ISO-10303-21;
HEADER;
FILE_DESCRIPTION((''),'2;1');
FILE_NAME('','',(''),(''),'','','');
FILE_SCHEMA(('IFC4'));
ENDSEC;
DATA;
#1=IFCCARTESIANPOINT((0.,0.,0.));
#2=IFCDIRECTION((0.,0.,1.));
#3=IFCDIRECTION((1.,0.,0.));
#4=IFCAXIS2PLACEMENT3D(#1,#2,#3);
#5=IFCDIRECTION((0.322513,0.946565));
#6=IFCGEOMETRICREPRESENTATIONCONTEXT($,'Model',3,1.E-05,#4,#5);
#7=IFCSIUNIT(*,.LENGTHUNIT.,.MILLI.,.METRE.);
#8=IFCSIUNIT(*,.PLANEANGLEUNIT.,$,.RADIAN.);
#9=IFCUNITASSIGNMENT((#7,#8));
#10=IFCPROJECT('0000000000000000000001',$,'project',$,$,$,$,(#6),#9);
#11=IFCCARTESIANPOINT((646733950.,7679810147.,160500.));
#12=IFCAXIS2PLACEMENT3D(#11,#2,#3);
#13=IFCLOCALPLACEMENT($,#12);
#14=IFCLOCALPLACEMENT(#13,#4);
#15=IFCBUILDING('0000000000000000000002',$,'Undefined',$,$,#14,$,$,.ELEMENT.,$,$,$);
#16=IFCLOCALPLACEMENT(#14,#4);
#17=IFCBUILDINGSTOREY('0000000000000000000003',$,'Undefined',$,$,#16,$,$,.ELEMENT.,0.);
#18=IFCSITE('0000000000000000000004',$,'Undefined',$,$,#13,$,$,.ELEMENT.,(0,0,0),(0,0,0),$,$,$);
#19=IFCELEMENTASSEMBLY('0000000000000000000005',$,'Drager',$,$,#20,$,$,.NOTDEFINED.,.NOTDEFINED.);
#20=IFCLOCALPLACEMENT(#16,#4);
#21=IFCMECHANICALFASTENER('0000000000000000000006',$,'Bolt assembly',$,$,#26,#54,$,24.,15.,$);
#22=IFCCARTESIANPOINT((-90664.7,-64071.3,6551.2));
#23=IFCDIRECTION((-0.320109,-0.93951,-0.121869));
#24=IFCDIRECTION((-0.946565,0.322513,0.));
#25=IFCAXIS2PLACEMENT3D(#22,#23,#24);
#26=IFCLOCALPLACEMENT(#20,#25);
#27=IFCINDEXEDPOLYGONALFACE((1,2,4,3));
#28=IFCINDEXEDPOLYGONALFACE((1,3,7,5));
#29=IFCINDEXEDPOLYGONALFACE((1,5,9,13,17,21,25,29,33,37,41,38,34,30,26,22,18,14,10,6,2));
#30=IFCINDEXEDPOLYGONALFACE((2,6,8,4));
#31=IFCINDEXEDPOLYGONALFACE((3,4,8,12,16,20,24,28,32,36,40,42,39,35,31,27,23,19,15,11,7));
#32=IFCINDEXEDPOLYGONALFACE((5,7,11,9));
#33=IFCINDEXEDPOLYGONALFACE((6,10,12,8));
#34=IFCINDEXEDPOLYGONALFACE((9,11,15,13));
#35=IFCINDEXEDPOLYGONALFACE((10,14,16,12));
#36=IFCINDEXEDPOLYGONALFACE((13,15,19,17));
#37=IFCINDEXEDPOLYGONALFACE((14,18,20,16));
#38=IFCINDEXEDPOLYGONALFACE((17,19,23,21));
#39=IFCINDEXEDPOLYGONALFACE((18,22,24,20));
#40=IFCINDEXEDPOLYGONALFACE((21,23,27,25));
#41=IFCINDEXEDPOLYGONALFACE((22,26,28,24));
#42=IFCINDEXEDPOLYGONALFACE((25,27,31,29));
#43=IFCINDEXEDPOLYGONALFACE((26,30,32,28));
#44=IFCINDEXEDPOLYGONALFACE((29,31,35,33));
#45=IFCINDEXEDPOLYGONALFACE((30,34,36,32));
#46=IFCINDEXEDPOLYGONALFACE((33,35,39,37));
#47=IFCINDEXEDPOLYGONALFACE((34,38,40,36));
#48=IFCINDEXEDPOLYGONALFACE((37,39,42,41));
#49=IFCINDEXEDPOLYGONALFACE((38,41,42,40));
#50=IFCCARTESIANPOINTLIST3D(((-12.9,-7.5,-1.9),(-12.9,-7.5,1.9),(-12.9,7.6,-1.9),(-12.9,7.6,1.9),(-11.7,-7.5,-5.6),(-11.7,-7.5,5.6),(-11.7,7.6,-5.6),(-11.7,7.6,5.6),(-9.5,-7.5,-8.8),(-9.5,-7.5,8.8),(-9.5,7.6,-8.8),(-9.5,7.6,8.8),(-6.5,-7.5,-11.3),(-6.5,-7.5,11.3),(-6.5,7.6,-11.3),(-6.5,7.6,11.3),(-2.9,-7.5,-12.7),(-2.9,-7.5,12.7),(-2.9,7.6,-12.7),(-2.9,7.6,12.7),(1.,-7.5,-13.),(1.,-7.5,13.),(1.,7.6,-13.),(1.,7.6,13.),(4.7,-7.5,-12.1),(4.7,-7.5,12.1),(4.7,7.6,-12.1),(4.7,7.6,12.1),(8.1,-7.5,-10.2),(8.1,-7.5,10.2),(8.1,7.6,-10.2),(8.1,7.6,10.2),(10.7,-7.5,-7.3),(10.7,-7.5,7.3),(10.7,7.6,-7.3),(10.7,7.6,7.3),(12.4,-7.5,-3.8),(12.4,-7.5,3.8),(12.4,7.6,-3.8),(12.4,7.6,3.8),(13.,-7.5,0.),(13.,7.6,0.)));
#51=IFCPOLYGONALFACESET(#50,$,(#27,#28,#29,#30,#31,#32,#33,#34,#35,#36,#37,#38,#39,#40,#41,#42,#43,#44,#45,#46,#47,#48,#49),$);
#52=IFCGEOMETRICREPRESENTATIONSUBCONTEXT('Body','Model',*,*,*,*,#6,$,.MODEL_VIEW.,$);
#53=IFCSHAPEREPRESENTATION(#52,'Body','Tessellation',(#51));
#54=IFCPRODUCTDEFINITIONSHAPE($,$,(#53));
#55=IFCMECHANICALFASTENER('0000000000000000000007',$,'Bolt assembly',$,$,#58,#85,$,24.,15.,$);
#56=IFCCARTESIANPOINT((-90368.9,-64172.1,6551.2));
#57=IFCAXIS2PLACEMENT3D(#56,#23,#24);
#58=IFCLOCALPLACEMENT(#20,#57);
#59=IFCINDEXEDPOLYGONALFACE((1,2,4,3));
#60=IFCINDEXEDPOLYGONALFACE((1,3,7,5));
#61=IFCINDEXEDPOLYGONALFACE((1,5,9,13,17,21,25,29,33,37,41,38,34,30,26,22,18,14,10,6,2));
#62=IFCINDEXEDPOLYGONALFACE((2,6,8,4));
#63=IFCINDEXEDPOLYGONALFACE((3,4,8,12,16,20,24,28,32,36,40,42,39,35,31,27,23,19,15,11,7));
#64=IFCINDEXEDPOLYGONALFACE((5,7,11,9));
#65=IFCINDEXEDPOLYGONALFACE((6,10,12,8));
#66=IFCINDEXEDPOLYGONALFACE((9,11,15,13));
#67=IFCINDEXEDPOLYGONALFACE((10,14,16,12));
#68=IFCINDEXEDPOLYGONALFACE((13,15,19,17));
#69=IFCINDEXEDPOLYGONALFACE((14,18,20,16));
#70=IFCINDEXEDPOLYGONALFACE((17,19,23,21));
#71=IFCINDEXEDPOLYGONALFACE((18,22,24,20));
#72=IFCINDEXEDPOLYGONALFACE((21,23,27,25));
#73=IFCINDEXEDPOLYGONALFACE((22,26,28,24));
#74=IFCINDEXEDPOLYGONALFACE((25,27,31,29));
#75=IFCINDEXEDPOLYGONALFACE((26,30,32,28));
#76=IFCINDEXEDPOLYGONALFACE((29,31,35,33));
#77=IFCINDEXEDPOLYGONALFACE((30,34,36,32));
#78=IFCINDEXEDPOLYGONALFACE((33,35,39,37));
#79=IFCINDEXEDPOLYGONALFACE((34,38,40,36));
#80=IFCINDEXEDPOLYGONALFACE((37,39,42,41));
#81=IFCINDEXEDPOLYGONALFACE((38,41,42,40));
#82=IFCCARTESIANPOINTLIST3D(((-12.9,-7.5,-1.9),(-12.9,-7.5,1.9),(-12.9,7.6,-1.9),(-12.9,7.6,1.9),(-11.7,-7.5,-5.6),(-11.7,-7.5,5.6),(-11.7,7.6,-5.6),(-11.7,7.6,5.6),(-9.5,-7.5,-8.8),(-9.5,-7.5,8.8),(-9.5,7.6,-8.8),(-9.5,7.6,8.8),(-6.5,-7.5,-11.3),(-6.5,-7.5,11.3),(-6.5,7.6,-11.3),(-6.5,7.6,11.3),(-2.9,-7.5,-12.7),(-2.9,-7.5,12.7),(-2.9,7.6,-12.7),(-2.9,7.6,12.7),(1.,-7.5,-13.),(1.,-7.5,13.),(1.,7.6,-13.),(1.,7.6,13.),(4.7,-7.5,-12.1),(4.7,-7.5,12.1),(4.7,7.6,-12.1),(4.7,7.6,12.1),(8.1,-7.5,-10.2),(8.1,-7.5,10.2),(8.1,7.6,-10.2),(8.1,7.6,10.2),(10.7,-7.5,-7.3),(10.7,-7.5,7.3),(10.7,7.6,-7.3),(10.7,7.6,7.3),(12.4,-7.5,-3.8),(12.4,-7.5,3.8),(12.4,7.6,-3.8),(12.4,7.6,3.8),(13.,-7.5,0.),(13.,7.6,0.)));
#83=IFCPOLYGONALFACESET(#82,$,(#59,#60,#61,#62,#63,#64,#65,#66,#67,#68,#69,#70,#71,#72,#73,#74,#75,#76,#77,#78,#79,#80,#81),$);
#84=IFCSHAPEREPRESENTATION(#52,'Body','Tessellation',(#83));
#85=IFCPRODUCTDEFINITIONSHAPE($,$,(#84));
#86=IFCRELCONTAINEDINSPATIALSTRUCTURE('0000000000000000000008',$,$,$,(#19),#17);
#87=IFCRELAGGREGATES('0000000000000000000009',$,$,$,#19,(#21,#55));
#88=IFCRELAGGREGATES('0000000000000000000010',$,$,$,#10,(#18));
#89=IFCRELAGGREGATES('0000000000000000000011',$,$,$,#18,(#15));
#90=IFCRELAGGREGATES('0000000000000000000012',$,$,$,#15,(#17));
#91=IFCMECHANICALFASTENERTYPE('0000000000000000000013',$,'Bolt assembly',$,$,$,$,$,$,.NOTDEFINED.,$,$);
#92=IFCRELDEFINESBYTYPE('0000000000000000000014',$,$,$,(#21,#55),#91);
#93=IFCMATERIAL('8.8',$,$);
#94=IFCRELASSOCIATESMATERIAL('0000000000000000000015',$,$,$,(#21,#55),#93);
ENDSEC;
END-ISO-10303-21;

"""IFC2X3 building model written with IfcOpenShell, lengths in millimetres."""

from ifc_helpers import new_model, si_unit, direction, frame, origin_with_axes, origin_2d_with_axis, place, context, subcontext, project, spatial, circle, extrude, source, transform, mapped, material, type_object, element, aggregate, save


model = new_model("IFC2X3")

# Units and contexts
model_context = context("Model", 3, precision=1e-05, world=origin_with_axes(), true_north=direction((0.322513, 0.946565)))
body_context = subcontext(model_context, "Body", "Model", "MODEL_VIEW")
ifc_project = project(units=[si_unit("LENGTHUNIT", "METRE", prefix="MILLI"), si_unit("PLANEANGLEUNIT", "RADIAN")], contexts=[model_context])

# Site, building, storey
site_placement = place(None, frame((646733950.0, 7679810147.0, 160500.0), z_axis=(0.0, 0.0, 1.0), x_axis=(1.0, 0.0, 0.0)))
site = spatial("IfcSite", under=ifc_project, at=site_placement, Name="Undefined", CompositionType="ELEMENT", RefLatitude=(0, 0, 0), RefLongitude=(0, 0, 0))
building_placement = place(site_placement, origin_with_axes())
building = spatial("IfcBuilding", under=site, at=building_placement, Name="Undefined", CompositionType="ELEMENT")
storey_placement = place(building_placement, origin_with_axes())
storey = spatial("IfcBuildingStorey", under=building, at=storey_placement, Name="Undefined", CompositionType="ELEMENT", Elevation=0.0)

# Element assembly
assembly_1_placement = place(storey_placement, origin_with_axes())
assembly_1 = element("IfcElementAssembly", 1, at=assembly_1_placement, inside=storey, Name="Drager", AssemblyPlace="NOTDEFINED", PredefinedType="NOTDEFINED")

# Shared definitions
ifc_material_1 = material(Name="8.8")
mechanical_fastener_type = type_object("IfcMechanicalFastenerType", Name="Bolt assembly")

# Mechanical fasteners
shared_shape_1 = source(origin_with_axes(), body_context, "Body", "SweptSolid", [
    extrude(circle(Radius=13.0, at=origin_2d_with_axis()), frame((0.0, -7.5, 0.0), z_axis=(0.0, 1.0, 0.0), x_axis=(1.0, 0.0, 0.0)), (0.0, 0.0, 1.0), 15.1),
])
mechanical_fastener_1_placement = place(assembly_1_placement, frame((-90664.7, -64071.3, 6551.2), z_axis=(-0.320109, -0.93951, -0.121869), x_axis=(-0.946565, 0.322513, 0.0)))
mechanical_fastener_1 = element("IfcMechanicalFastener", 2, at=mechanical_fastener_1_placement, type_object=mechanical_fastener_type, material=ifc_material_1, Name="Bolt assembly", NominalDiameter=24.0, NominalLength=15.0, context=body_context, shape_type="MappedRepresentation", body=[
    mapped(shared_shape_1, transform((0.0, 0.0, 0.0))),
])
shared_shape_2 = source(origin_with_axes(), body_context, "Body", "SweptSolid", [
    extrude(circle(Radius=13.0, at=origin_2d_with_axis()), frame((0.0, -7.5, 0.0), z_axis=(0.0, 1.0, 0.0), x_axis=(1.0, 0.0, 0.0)), (0.0, 0.0, 1.0), 15.1),
])
mechanical_fastener_2_placement = place(assembly_1_placement, frame((-90368.9, -64172.1, 6551.2), z_axis=(-0.320109, -0.93951, -0.121869), x_axis=(-0.946565, 0.322513, 0.0)))
mechanical_fastener_2 = element("IfcMechanicalFastener", 3, at=mechanical_fastener_2_placement, type_object=mechanical_fastener_type, material=ifc_material_1, Name="Bolt assembly", NominalDiameter=24.0, NominalLength=15.0, context=body_context, shape_type="MappedRepresentation", body=[
    mapped(shared_shape_2, transform((0.0, 0.0, 0.0))),
])
aggregate(assembly_1, [mechanical_fastener_1, mechanical_fastener_2])

save(model, "model.ifc")
